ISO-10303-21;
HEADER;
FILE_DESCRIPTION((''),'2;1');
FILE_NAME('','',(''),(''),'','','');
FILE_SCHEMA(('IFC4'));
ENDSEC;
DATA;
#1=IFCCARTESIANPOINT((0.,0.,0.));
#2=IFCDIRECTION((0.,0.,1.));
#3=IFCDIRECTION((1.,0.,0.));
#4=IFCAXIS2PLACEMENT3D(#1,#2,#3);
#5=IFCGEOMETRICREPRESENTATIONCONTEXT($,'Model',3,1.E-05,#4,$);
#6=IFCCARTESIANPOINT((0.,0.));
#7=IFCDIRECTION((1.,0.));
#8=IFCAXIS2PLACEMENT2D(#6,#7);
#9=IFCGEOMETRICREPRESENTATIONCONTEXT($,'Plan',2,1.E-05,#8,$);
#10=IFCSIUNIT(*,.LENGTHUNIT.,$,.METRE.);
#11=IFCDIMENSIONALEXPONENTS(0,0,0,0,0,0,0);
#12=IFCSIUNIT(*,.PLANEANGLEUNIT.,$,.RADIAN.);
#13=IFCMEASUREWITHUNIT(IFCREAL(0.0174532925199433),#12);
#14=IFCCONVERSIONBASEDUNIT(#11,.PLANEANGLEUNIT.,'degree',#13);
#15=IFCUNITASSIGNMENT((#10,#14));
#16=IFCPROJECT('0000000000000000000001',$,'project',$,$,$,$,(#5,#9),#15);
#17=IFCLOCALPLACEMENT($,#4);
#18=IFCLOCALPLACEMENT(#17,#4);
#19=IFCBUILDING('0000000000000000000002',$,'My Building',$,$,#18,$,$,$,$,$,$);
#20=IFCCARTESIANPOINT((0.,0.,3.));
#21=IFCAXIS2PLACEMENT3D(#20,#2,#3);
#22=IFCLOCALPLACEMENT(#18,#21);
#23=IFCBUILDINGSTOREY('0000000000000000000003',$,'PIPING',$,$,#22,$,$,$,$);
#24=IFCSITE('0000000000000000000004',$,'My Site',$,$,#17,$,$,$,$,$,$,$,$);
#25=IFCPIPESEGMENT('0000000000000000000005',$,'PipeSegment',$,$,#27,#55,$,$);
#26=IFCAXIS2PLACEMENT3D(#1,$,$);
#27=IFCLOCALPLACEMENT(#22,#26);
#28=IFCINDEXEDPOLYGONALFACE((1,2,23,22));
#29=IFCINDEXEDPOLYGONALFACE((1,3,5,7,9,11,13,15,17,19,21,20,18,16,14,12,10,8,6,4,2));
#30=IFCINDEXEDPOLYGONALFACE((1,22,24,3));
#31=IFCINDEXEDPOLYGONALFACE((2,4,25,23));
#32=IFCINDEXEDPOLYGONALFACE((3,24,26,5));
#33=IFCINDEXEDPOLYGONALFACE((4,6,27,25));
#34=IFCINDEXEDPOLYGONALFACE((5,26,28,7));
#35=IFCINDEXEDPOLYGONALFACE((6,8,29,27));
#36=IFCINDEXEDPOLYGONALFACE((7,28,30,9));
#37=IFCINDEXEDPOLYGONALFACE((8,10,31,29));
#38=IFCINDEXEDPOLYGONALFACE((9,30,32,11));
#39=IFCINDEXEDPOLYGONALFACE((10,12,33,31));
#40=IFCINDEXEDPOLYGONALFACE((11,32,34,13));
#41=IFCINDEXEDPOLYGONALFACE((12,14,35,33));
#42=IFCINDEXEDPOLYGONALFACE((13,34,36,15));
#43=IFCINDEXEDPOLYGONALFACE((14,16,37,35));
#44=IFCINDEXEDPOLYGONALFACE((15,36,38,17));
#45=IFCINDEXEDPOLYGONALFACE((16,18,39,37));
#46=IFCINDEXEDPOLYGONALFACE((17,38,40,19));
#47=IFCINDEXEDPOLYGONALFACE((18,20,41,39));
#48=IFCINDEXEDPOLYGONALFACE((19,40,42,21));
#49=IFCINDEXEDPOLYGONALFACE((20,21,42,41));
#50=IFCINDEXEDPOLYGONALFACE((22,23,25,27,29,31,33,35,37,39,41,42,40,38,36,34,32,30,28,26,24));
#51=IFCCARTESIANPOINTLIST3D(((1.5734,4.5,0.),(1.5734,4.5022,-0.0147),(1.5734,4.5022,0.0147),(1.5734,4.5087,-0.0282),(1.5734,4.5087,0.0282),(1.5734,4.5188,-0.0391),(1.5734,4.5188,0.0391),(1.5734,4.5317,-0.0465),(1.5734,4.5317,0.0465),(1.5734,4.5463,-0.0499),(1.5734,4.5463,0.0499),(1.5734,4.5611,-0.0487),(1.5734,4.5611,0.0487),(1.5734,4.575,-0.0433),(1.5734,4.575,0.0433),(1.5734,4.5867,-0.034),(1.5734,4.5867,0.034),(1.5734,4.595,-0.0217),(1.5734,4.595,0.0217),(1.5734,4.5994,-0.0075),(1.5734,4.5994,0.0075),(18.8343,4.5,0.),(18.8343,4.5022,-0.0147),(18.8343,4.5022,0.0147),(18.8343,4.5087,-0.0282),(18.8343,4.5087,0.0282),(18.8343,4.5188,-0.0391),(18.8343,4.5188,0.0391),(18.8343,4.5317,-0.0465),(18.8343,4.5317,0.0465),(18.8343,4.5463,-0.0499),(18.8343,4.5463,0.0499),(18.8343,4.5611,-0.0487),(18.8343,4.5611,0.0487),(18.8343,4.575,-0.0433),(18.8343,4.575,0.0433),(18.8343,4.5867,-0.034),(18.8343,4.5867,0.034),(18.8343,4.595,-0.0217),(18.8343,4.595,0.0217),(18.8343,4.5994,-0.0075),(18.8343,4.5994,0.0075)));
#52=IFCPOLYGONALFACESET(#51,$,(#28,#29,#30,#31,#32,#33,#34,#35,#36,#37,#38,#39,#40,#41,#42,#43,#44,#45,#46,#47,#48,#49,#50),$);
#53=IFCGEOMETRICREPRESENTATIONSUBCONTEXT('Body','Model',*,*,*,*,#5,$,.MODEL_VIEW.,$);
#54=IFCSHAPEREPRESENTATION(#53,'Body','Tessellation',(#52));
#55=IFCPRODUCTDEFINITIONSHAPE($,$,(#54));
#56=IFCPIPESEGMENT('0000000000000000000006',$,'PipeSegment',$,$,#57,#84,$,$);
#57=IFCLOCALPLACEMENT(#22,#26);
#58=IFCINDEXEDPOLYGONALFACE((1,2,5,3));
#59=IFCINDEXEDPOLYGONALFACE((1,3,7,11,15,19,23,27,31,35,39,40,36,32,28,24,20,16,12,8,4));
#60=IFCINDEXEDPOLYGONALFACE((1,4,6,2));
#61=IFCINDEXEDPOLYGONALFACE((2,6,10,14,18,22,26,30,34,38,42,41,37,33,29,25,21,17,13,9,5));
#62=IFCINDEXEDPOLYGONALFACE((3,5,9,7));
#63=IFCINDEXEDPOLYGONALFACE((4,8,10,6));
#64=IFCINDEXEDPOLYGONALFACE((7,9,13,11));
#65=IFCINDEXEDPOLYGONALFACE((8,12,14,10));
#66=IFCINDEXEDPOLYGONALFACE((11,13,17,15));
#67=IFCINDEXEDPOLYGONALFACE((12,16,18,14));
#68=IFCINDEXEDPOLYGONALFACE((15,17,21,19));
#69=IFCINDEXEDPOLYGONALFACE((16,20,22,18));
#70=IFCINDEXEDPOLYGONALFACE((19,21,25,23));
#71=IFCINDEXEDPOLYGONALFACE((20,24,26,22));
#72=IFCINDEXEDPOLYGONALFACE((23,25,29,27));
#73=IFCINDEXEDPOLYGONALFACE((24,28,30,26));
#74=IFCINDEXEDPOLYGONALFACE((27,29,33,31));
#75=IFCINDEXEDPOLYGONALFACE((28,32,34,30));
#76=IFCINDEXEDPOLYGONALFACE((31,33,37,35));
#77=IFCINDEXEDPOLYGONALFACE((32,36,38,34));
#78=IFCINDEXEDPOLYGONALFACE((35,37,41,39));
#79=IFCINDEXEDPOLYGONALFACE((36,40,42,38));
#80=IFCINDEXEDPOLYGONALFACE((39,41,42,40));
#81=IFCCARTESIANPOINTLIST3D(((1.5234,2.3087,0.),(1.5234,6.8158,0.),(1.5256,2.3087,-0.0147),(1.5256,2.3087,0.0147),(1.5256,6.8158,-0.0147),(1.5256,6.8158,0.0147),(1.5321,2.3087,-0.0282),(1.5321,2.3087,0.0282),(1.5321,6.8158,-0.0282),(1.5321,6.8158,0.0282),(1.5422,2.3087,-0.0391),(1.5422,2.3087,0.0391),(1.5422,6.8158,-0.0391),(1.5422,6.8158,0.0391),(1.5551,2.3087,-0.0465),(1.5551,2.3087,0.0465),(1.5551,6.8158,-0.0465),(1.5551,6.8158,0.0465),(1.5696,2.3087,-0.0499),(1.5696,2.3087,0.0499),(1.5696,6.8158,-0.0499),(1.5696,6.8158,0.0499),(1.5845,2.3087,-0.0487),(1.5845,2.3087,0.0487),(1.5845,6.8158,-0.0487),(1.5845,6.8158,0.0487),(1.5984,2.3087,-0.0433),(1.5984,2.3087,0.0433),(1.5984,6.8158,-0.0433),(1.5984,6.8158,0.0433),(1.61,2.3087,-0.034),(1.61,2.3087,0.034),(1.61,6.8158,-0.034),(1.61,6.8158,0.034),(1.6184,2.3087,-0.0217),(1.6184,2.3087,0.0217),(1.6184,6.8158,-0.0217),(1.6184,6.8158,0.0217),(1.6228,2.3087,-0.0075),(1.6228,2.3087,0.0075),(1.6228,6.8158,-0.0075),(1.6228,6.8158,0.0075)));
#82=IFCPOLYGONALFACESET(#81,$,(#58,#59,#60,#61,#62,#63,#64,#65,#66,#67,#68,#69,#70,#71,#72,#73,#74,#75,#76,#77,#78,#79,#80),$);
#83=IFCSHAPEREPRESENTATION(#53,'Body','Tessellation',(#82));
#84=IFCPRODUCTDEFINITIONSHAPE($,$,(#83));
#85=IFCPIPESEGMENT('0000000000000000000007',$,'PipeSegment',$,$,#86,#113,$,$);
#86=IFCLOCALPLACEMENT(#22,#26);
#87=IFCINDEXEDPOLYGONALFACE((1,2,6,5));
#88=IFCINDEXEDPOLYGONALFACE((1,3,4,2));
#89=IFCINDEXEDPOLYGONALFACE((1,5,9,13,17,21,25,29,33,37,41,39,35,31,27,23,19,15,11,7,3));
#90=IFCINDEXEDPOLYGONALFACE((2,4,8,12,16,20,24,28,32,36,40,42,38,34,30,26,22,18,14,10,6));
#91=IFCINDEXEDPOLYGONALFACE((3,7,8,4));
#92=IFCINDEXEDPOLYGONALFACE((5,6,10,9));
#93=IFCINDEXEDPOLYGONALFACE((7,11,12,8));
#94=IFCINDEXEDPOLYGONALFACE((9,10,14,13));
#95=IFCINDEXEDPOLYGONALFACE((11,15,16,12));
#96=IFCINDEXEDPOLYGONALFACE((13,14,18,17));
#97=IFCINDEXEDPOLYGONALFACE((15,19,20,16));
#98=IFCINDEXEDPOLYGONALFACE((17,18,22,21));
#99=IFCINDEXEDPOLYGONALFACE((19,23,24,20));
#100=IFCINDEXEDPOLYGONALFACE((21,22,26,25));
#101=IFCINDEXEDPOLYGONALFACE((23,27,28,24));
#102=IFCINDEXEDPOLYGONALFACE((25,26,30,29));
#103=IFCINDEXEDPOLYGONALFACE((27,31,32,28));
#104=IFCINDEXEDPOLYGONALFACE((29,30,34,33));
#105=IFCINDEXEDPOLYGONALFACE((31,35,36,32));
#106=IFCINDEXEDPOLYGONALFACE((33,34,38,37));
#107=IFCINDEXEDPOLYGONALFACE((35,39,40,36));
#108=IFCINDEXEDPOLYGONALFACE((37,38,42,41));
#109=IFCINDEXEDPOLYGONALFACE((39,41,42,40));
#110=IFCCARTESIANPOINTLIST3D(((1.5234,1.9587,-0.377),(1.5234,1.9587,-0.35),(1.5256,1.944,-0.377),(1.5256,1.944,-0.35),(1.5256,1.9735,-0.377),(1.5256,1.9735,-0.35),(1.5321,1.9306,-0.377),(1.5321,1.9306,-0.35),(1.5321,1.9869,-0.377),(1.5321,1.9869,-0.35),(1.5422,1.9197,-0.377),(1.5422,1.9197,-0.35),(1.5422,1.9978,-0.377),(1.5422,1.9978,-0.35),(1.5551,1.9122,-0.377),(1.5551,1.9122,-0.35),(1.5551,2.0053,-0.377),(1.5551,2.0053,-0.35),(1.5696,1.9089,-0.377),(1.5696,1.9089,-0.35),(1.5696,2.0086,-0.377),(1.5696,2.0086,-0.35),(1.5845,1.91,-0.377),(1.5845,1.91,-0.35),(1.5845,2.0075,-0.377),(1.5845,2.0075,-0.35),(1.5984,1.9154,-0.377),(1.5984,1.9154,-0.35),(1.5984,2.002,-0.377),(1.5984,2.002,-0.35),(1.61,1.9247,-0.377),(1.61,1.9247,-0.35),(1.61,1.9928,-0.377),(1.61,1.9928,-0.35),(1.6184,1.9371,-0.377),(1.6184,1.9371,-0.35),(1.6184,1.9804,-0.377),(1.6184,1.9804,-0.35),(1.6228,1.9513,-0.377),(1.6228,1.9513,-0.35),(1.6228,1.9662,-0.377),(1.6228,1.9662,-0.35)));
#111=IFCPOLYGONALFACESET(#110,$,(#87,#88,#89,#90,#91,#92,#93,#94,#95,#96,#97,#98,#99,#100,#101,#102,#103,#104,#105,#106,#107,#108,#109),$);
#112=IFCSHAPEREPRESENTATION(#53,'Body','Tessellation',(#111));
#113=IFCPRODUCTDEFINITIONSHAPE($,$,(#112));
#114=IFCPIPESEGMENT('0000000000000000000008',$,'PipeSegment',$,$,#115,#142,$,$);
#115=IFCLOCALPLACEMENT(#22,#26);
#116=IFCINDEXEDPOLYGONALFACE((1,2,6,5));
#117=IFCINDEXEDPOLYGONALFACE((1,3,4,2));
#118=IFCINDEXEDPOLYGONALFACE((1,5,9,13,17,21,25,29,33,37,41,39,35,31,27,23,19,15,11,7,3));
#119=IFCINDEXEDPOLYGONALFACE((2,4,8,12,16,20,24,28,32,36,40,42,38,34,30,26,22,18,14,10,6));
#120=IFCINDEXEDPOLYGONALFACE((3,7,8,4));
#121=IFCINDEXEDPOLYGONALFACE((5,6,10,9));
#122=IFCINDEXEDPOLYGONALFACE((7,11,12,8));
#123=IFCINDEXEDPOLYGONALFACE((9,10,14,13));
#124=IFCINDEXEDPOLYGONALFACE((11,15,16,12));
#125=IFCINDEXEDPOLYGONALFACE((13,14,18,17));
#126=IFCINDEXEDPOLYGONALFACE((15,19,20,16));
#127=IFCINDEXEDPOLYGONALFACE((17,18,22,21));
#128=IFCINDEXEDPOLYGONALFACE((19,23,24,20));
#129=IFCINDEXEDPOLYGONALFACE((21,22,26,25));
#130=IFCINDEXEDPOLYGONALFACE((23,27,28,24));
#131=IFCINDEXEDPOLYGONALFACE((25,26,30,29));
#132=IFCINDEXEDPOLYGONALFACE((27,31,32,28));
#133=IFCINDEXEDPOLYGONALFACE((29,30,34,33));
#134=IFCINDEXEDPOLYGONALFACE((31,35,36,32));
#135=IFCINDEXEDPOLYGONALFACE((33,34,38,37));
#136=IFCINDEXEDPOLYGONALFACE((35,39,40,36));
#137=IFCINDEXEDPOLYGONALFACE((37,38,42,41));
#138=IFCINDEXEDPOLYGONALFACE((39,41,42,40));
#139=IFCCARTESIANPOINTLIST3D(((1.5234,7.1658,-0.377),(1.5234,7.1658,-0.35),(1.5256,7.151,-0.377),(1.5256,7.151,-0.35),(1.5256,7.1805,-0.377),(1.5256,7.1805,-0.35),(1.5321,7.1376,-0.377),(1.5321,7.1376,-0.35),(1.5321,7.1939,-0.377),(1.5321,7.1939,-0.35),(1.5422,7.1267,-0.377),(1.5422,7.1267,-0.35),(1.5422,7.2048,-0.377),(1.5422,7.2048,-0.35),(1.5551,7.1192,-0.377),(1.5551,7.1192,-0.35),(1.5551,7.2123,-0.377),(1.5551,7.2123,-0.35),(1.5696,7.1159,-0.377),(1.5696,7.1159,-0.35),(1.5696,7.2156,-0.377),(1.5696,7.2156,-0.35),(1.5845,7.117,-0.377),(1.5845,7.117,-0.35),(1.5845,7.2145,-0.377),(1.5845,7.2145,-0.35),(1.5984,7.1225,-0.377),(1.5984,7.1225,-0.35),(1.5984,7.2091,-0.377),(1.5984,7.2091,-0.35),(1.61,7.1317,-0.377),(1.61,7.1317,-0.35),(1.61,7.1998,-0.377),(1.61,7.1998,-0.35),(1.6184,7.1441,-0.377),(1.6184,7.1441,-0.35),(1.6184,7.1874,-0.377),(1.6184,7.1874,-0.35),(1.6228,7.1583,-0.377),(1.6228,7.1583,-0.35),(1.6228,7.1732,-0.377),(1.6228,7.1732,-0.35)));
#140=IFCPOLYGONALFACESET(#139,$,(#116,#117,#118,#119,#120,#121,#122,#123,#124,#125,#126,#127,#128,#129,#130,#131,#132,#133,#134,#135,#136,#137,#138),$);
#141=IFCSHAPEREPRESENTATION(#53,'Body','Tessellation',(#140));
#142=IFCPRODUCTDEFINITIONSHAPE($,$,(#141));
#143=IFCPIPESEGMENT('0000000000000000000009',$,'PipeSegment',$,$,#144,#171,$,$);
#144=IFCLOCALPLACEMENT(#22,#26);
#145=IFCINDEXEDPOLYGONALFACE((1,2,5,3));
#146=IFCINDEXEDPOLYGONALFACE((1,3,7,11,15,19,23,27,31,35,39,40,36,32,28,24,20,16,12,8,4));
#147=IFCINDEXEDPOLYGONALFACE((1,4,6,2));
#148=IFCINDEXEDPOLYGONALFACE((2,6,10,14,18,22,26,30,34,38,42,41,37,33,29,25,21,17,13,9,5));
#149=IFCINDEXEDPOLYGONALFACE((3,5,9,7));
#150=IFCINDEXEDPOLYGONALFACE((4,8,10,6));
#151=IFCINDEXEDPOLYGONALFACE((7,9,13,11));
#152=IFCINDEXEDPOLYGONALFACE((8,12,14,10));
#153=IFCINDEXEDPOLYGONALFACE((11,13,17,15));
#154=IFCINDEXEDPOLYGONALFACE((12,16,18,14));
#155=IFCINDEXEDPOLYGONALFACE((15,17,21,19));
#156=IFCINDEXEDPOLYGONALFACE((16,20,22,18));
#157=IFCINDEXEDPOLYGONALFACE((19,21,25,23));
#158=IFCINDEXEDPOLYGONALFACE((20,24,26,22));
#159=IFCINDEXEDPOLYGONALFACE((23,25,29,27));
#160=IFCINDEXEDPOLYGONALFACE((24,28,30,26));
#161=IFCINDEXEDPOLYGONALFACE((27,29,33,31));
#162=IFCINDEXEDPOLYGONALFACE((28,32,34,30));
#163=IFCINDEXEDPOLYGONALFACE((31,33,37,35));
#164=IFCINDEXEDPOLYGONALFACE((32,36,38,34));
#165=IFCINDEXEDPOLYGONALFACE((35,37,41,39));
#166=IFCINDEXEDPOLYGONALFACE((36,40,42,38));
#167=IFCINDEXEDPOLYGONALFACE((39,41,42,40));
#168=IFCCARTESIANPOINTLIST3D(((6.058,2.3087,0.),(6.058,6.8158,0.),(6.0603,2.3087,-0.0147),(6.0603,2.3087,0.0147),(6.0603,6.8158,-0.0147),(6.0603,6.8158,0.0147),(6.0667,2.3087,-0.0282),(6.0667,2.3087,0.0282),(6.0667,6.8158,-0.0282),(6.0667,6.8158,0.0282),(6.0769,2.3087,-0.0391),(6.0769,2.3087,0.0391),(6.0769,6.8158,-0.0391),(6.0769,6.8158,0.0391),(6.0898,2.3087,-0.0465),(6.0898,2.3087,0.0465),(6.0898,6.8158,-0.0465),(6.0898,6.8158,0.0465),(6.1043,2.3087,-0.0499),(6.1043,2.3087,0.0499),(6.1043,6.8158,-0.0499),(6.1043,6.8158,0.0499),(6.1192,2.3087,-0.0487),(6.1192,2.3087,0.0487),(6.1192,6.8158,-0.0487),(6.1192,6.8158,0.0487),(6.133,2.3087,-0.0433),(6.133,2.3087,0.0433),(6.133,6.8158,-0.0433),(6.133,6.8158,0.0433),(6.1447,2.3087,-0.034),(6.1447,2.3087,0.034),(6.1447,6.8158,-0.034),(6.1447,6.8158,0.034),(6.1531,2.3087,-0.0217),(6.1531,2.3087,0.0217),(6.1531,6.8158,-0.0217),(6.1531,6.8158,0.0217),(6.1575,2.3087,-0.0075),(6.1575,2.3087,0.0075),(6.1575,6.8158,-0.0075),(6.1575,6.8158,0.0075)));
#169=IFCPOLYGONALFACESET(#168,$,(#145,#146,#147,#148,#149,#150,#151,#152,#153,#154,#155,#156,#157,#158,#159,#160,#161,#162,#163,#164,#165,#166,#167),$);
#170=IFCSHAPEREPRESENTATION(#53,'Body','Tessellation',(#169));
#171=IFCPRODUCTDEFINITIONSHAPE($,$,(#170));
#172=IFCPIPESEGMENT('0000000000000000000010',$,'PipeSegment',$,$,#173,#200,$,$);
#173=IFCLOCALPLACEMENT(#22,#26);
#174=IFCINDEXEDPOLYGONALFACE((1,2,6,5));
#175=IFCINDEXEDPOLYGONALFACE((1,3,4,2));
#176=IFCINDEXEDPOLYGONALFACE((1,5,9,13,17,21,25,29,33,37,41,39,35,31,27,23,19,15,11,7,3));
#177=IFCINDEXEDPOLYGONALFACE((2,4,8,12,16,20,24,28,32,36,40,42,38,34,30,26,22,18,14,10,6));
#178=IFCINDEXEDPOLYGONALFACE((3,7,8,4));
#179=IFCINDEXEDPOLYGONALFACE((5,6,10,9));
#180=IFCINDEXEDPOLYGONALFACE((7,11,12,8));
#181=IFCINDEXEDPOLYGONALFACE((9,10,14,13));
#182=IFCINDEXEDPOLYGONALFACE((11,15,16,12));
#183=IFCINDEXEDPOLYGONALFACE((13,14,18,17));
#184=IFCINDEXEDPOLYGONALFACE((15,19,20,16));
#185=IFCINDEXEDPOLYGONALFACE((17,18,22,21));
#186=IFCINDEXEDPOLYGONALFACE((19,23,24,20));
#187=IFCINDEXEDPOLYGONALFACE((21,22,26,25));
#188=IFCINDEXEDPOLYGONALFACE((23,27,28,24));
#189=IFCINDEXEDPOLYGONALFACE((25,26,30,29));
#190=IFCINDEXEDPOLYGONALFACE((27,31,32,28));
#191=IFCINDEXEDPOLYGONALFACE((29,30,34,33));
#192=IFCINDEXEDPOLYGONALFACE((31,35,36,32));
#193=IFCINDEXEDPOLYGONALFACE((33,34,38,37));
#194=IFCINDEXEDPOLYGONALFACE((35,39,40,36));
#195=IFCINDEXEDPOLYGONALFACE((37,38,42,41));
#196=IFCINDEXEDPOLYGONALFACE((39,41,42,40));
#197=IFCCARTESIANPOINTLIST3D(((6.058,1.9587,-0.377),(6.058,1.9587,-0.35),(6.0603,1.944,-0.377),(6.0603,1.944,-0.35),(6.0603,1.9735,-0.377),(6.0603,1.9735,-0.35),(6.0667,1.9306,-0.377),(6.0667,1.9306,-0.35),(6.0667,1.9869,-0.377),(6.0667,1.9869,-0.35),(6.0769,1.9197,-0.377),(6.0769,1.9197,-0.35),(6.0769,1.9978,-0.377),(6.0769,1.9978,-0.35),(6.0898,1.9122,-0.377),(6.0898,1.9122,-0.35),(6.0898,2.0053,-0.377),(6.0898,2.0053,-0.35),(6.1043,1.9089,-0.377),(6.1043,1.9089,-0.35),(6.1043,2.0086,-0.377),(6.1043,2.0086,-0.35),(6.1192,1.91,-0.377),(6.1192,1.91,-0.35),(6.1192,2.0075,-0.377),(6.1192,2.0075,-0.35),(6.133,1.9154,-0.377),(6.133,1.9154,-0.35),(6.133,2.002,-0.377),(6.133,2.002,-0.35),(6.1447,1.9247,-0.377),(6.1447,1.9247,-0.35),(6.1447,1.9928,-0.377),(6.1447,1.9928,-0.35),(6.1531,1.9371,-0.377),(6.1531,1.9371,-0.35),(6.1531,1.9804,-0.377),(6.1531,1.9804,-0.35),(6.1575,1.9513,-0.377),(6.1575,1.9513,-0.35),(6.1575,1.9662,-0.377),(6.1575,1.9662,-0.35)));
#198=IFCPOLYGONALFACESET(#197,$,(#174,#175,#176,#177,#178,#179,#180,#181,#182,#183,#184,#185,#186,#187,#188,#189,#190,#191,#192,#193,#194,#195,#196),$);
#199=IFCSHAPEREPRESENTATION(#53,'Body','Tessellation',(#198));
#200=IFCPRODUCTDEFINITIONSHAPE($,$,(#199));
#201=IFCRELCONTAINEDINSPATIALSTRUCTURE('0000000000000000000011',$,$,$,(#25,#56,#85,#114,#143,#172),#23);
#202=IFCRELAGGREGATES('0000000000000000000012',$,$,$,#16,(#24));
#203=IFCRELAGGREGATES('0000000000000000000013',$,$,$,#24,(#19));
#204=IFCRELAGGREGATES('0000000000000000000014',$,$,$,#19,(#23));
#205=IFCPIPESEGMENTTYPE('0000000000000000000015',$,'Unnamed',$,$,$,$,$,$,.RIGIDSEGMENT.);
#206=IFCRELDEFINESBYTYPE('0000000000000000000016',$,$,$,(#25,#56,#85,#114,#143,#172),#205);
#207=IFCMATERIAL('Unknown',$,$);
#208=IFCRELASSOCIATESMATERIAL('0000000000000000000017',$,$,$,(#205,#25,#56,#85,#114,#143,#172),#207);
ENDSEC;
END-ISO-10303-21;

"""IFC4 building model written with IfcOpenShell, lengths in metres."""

from ifc_helpers import new_model, entity, si_unit, converted_unit, frame, origin_with_axes, origin_2d_with_axis, place, context, subcontext, project, spatial, circle, extrude, material, material_profile, profile_set, profile_usage, type_object, element, save


model = new_model("IFC4")

# Units and contexts
model_context = context("Model", 3, precision=1e-05, world=origin_with_axes())
plan_context = context("Plan", 2, precision=1e-05, world=origin_2d_with_axis())
body_context = subcontext(model_context, "Body", "Model", "MODEL_VIEW")
ifc_project = project(units=[si_unit("LENGTHUNIT", "METRE"), converted_unit("PLANEANGLEUNIT", "degree", entity("IfcReal", 0.0174532925199433), si_unit("PLANEANGLEUNIT", "RADIAN"), dimensions=[0, 0, 0, 0, 0, 0, 0])], contexts=[model_context, plan_context])

# Site, building, storey
site_placement = place(None, origin_with_axes())
site = spatial("IfcSite", under=ifc_project, at=site_placement, Name="My Site")
building_placement = place(site_placement, origin_with_axes())
building = spatial("IfcBuilding", under=site, at=building_placement, Name="My Building")
storey_placement = place(building_placement, frame((0.0, 0.0, 3.0), z_axis=(0.0, 0.0, 1.0), x_axis=(1.0, 0.0, 0.0)))
storey = spatial("IfcBuildingStorey", under=building, at=storey_placement, Name="PIPING")

# Pipe segments
ifc_material = material(Name="Unknown")
ifc_material_profile = material_profile(ifc_material, circle(Radius=0.05))
ifc_profile_set = profile_set([ifc_material_profile])
ifc_profile_usage_1 = profile_usage(ifc_profile_set, cardinal=5)
pipe_segment_type = type_object("IfcPipeSegmentType", Name="Unnamed", PredefinedType="RIGIDSEGMENT", material=ifc_profile_set)
pipe_segment_1_placement = place(storey_placement, frame((18.8343, 4.55, 0.0), z_axis=(-1.0, 0.0, 0.0), x_axis=(0.0, -1.0, 0.0)))
element("IfcPipeSegment", 1, at=pipe_segment_1_placement, inside=storey, type_object=pipe_segment_type, material=ifc_profile_usage_1, Name="PipeSegment", context=body_context, shape_type="SweptSolid", body=[
    extrude(circle(Radius=0.05), origin_with_axes(), (0.0, 0.0, 1.0), 17.2609),
])
ifc_profile_usage_2 = profile_usage(ifc_profile_set, cardinal=5)
pipe_segment_2_placement = place(storey_placement, frame((1.5734, 2.3087, 0.0), z_axis=(0.0, 1.0, 0.0), x_axis=(-1.0, 0.0, 0.0)))
element("IfcPipeSegment", 2, at=pipe_segment_2_placement, inside=storey, type_object=pipe_segment_type, material=ifc_profile_usage_2, Name="PipeSegment", context=body_context, shape_type="SweptSolid", body=[
    extrude(circle(Radius=0.05), origin_with_axes(), (0.0, 0.0, 1.0), 4.507),
])
ifc_profile_usage_3 = profile_usage(ifc_profile_set, cardinal=5)
pipe_segment_3_placement = place(storey_placement, frame((1.5734, 1.9587, -0.35), z_axis=(0.0, 0.0, -1.0), x_axis=(-1.0, 0.0, 0.0)))
element("IfcPipeSegment", 3, at=pipe_segment_3_placement, inside=storey, type_object=pipe_segment_type, material=ifc_profile_usage_3, Name="PipeSegment", context=body_context, shape_type="SweptSolid", body=[
    extrude(circle(Radius=0.05), origin_with_axes(), (0.0, 0.0, 1.0), 0.027),
])
ifc_profile_usage_4 = profile_usage(ifc_profile_set, cardinal=5)
pipe_segment_4_placement = place(storey_placement, frame((1.5734, 7.1658, -0.35), z_axis=(0.0, 0.0, -1.0), x_axis=(-1.0, 0.0, 0.0)))
element("IfcPipeSegment", 4, at=pipe_segment_4_placement, inside=storey, type_object=pipe_segment_type, material=ifc_profile_usage_4, Name="PipeSegment", context=body_context, shape_type="SweptSolid", body=[
    extrude(circle(Radius=0.05), origin_with_axes(), (0.0, 0.0, 1.0), 0.027),
])
ifc_profile_usage_5 = profile_usage(ifc_profile_set, cardinal=5)
pipe_segment_5_placement = place(storey_placement, frame((6.108, 2.3087, 0.0), z_axis=(0.0, 1.0, 0.0), x_axis=(-1.0, 0.0, 0.0)))
element("IfcPipeSegment", 5, at=pipe_segment_5_placement, inside=storey, type_object=pipe_segment_type, material=ifc_profile_usage_5, Name="PipeSegment", context=body_context, shape_type="SweptSolid", body=[
    extrude(circle(Radius=0.05), origin_with_axes(), (0.0, 0.0, 1.0), 4.507),
])
ifc_profile_usage_6 = profile_usage(ifc_profile_set, cardinal=5)
pipe_segment_6_placement = place(storey_placement, frame((6.108, 1.9587, -0.35), z_axis=(0.0, 0.0, -1.0), x_axis=(-1.0, 0.0, 0.0)))
element("IfcPipeSegment", 6, at=pipe_segment_6_placement, inside=storey, type_object=pipe_segment_type, material=ifc_profile_usage_6, Name="PipeSegment", context=body_context, shape_type="SweptSolid", body=[
    extrude(circle(Radius=0.05), origin_with_axes(), (0.0, 0.0, 1.0), 0.027),
])

save(model, "model.ifc")
